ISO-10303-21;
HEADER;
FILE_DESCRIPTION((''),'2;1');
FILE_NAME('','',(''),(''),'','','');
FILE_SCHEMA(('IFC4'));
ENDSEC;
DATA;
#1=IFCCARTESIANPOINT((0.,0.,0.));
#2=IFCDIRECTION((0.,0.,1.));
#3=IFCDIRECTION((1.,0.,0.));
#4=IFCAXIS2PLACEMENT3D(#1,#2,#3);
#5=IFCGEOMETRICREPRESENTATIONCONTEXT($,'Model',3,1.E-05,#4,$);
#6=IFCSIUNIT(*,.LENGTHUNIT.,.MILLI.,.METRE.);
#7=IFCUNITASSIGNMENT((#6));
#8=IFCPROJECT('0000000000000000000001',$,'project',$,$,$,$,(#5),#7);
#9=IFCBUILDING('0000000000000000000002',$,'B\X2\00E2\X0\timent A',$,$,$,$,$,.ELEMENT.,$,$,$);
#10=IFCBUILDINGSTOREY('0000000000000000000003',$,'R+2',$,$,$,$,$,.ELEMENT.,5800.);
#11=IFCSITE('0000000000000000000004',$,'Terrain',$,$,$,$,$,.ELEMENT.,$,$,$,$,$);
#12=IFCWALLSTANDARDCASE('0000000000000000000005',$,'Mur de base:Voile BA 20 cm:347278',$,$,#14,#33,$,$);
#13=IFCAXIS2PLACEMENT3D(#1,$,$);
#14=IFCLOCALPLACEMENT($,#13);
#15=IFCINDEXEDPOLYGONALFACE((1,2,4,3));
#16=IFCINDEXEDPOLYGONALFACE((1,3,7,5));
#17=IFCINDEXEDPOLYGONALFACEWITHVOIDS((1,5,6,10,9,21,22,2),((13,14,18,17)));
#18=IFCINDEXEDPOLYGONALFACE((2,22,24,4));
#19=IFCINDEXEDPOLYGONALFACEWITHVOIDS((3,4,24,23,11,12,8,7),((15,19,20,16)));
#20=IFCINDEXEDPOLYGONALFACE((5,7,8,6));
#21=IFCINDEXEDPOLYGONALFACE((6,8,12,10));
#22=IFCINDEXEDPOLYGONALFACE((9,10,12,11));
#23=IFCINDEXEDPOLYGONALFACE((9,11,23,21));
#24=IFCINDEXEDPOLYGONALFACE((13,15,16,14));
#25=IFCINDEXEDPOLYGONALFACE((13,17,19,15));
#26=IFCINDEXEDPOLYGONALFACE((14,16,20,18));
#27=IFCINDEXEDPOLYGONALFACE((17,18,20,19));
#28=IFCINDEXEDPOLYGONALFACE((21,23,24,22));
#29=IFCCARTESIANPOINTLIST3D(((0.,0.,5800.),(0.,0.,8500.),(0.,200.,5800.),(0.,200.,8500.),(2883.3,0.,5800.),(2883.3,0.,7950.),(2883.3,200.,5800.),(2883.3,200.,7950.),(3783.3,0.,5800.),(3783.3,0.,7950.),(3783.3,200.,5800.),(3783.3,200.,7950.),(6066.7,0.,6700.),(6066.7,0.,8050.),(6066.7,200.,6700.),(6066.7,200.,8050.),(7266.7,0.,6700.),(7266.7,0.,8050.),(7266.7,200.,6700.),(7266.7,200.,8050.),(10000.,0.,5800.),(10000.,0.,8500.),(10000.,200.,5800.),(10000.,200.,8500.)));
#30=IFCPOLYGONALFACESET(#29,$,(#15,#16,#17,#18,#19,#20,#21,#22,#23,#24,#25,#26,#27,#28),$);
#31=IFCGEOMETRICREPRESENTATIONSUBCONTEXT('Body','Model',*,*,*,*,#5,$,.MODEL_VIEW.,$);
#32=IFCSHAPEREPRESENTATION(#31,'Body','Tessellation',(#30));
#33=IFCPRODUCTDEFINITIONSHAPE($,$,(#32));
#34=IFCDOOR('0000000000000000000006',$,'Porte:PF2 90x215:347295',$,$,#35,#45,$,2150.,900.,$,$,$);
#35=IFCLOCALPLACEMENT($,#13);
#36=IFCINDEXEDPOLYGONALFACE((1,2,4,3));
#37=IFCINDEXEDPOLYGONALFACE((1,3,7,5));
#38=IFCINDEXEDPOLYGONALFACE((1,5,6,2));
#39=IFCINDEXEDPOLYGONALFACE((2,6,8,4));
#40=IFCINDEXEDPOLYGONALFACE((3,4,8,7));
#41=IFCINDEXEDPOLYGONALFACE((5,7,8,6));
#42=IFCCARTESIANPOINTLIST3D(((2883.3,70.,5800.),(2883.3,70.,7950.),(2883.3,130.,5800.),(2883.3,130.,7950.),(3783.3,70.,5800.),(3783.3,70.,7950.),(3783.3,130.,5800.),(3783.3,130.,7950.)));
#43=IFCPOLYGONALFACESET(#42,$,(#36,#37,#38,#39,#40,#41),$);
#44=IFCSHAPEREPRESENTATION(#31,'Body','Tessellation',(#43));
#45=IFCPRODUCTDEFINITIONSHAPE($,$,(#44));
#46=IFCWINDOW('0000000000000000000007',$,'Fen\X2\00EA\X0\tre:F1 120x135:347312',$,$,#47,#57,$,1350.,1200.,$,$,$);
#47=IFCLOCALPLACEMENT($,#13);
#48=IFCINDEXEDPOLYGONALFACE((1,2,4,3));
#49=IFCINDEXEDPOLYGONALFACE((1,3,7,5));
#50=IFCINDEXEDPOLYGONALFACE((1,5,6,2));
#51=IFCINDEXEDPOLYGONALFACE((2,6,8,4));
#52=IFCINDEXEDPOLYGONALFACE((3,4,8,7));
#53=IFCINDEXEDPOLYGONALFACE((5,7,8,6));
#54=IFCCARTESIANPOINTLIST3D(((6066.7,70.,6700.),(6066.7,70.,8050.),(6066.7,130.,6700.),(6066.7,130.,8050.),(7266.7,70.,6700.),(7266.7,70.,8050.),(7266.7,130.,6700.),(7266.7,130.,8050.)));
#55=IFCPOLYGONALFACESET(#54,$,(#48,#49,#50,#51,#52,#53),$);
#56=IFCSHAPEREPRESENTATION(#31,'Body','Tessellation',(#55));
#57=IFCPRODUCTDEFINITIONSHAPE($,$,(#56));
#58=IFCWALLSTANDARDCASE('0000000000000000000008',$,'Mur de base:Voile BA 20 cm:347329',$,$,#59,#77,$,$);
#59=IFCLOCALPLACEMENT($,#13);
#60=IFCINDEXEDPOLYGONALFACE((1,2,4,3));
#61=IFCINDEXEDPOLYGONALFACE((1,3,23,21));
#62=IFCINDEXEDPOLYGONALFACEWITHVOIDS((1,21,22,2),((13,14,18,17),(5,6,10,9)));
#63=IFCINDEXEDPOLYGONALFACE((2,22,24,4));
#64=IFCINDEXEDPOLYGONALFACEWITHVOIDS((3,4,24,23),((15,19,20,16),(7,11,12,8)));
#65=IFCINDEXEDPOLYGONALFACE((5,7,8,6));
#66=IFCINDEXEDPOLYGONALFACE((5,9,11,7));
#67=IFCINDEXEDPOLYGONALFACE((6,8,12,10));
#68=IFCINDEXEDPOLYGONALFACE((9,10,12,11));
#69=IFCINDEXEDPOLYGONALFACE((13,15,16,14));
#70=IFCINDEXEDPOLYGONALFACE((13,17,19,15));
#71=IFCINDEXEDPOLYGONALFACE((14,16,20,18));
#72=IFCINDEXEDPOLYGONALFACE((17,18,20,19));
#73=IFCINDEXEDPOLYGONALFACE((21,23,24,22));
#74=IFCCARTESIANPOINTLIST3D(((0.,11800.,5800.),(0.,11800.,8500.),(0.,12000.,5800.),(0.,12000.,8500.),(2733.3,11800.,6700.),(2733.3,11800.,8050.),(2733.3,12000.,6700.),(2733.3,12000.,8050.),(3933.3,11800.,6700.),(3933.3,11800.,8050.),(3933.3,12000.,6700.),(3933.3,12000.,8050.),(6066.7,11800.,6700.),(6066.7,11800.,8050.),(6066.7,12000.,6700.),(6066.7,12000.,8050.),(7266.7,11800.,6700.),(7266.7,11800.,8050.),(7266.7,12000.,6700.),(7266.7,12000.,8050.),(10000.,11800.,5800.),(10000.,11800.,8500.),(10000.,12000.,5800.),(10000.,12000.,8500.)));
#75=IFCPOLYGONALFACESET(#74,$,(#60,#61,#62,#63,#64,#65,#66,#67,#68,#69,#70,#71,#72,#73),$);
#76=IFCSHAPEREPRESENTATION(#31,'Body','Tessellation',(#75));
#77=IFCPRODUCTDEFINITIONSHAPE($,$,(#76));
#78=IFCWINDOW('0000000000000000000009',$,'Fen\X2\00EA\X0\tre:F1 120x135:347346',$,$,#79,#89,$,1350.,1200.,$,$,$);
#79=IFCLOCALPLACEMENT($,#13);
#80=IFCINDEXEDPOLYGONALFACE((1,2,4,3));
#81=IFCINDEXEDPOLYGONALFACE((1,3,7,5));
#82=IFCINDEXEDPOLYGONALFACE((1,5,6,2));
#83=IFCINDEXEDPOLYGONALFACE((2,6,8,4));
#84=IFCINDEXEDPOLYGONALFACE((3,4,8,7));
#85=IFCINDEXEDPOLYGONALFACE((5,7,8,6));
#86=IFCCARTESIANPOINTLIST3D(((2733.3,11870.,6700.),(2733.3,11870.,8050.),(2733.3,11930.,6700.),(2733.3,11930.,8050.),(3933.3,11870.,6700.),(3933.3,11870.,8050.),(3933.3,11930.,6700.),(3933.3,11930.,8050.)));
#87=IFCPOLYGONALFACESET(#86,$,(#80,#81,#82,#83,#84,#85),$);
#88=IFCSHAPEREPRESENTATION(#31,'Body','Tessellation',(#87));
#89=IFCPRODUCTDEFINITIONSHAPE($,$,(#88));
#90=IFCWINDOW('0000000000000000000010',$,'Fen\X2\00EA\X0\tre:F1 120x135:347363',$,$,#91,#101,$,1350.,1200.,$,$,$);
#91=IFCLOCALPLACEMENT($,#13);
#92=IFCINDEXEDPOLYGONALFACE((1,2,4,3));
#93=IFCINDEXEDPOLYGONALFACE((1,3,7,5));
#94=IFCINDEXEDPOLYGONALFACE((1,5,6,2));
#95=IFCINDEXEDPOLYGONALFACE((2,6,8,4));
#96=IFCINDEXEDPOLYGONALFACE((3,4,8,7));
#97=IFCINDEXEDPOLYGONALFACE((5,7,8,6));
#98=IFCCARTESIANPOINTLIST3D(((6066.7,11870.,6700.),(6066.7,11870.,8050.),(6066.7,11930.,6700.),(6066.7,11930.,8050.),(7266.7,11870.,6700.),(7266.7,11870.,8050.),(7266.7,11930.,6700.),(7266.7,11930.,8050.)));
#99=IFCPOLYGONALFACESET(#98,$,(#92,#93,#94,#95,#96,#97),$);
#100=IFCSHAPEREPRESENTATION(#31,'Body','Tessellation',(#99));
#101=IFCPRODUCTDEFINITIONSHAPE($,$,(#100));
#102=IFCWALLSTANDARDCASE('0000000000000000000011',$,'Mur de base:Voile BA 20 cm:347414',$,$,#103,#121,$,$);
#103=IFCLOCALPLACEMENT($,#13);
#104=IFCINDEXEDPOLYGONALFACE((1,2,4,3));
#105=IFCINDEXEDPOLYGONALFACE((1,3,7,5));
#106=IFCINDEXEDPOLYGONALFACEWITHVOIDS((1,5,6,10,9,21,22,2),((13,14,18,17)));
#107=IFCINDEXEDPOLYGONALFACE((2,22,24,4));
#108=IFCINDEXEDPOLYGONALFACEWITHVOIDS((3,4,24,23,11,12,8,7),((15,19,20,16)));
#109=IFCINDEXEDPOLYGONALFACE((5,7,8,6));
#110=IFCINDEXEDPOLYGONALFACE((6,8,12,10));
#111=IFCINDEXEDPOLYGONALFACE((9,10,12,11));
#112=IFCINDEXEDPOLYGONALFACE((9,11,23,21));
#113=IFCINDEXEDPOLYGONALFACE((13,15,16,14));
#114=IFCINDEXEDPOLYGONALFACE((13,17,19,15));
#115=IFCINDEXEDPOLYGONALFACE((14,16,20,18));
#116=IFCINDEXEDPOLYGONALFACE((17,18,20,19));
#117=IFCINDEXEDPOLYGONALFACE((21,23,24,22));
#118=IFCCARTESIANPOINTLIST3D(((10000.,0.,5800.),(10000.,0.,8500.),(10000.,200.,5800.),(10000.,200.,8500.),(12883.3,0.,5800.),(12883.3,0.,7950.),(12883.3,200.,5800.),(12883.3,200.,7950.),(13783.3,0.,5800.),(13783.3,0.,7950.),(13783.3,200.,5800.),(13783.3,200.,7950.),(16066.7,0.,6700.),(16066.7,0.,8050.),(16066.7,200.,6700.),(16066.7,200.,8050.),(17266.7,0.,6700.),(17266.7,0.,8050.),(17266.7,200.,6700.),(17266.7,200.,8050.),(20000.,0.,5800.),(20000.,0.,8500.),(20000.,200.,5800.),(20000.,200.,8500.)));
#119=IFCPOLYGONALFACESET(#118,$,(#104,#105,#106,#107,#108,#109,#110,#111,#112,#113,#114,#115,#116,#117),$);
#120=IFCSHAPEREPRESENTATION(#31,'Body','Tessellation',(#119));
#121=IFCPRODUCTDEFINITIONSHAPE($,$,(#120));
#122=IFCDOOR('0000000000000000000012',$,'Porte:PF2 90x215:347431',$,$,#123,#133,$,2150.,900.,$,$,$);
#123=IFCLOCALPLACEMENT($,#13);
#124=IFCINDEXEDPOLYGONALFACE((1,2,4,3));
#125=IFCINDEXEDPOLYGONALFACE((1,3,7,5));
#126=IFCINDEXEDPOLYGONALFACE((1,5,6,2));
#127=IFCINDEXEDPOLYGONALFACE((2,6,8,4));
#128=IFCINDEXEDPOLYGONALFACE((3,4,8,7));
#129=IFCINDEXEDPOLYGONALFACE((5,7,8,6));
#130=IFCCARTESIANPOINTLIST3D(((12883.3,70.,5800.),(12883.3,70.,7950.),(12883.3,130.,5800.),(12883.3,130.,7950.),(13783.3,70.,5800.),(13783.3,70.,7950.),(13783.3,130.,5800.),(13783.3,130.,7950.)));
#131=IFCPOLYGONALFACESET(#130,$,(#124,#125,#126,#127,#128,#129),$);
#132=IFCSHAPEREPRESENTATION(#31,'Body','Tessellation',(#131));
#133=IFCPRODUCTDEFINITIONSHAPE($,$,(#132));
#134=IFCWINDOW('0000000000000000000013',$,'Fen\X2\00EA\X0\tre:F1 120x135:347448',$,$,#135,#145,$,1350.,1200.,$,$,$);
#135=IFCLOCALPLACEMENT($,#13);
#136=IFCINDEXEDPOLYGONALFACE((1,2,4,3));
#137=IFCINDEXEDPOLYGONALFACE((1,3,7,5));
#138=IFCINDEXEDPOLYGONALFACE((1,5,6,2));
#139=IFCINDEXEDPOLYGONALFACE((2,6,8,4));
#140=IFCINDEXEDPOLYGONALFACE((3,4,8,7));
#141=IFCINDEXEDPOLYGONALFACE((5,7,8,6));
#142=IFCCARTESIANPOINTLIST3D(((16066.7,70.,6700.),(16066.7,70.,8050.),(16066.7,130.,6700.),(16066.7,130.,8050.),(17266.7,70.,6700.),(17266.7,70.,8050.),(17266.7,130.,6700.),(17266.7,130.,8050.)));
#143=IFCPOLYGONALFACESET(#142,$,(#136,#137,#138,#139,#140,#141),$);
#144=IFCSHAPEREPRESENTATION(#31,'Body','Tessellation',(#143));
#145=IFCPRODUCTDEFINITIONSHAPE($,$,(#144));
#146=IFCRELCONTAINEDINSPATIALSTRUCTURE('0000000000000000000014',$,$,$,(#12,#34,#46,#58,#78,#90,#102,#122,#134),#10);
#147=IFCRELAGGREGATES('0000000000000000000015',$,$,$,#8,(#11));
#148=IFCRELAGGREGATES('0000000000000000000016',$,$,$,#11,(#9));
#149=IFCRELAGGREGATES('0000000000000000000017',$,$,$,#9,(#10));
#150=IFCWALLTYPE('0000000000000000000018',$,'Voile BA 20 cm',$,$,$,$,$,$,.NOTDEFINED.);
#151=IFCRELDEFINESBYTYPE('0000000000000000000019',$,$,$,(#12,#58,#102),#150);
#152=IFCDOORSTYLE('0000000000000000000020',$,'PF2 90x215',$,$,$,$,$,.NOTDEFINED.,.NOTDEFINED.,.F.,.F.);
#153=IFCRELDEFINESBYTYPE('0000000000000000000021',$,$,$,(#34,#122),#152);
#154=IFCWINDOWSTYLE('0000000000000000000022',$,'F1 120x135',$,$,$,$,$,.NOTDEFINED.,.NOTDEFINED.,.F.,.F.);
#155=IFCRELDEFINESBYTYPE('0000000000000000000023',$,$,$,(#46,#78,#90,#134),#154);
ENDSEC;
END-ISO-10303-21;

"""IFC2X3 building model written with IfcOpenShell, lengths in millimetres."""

from ifc_helpers import new_model, si_unit, frame, frame_2d, origin_with_axes, place, context, subcontext, project, spatial, rectangle, extrude, type_object, element, fill, save


model = new_model("IFC2X3")

# Units and contexts
model_context = context("Model", 3, precision=1e-05, world=origin_with_axes())
body_context = subcontext(model_context, "Body", "Model", "MODEL_VIEW")
ifc_project = project(units=[si_unit("LENGTHUNIT", "METRE", prefix="MILLI")], contexts=[model_context])

# Site, building, storey
site = spatial("IfcSite", under=ifc_project, Name="Terrain", CompositionType="ELEMENT")
building = spatial("IfcBuilding", under=site, Name="Bâtiment A", CompositionType="ELEMENT")
storey = spatial("IfcBuildingStorey", under=building, Name="R+2", CompositionType="ELEMENT", Elevation=5800.0)

# Wall, openings, door, window
wall_type_1 = type_object("IfcWallType", Name="Voile BA 20 cm", PredefinedType="NOTDEFINED")
wall_1_placement = place(None, origin_with_axes())
wall_1 = element("IfcWallStandardCase", 1, at=wall_1_placement, inside=storey, type_object=wall_type_1, Name="Mur de base:Voile BA 20 cm:347278", context=body_context, shape_type="SweptSolid", body=[
    extrude(rectangle(XDim=10000.0, YDim=200.0, at=frame_2d((5000.0, 100.0))), frame((0.0, 0.0, 5800.0), z_axis=(0.0, 0.0, 1.0), x_axis=(1.0, 0.0, 0.0)), (0.0, 0.0, 1.0), 2700.0),
])
opening_1_placement = place(None, origin_with_axes())
opening_1 = element("IfcOpeningElement", 2, at=opening_1_placement, cuts=wall_1, context=body_context, shape_type="SweptSolid", body=[
    extrude(rectangle(XDim=900.0, YDim=320.0, at=frame_2d((3333.3, 100.0))), frame((0.0, 0.0, 5800.0), z_axis=(0.0, 0.0, 1.0), x_axis=(1.0, 0.0, 0.0)), (0.0, 0.0, 1.0), 2150.0),
])
opening_2_placement = place(None, origin_with_axes())
opening_2 = element("IfcOpeningElement", 3, at=opening_2_placement, cuts=wall_1, context=body_context, shape_type="SweptSolid", body=[
    extrude(rectangle(XDim=1200.0, YDim=320.0, at=frame_2d((6666.7, 100.0))), frame((0.0, 0.0, 6700.0), z_axis=(0.0, 0.0, 1.0), x_axis=(1.0, 0.0, 0.0)), (0.0, 0.0, 1.0), 1350.0),
])
door_style = type_object("IfcDoorStyle", Name="PF2 90x215", ConstructionType="NOTDEFINED", OperationType="NOTDEFINED", ParameterTakesPrecedence=False, Sizeable=False)
door_1_placement = place(None, origin_with_axes())
door_1 = element("IfcDoor", 4, at=door_1_placement, inside=storey, type_object=door_style, Name="Porte:PF2 90x215:347295", OverallHeight=2150.0, OverallWidth=900.0, context=body_context, shape_type="SweptSolid", body=[
    extrude(rectangle(XDim=900.0, YDim=60.0, at=frame_2d((3333.3, 100.0))), frame((0.0, 0.0, 5800.0), z_axis=(0.0, 0.0, 1.0), x_axis=(1.0, 0.0, 0.0)), (0.0, 0.0, 1.0), 2150.0),
])
fill(opening_1, door_1)
window_style = type_object("IfcWindowStyle", Name="F1 120x135", ConstructionType="NOTDEFINED", OperationType="NOTDEFINED", ParameterTakesPrecedence=False, Sizeable=False)
window_1_placement = place(None, origin_with_axes())
window_1 = element("IfcWindow", 5, at=window_1_placement, inside=storey, type_object=window_style, Name="Fenêtre:F1 120x135:347312", OverallHeight=1350.0, OverallWidth=1200.0, context=body_context, shape_type="SweptSolid", body=[
    extrude(rectangle(XDim=1200.0, YDim=60.0, at=frame_2d((6666.7, 100.0))), frame((0.0, 0.0, 6700.0), z_axis=(0.0, 0.0, 1.0), x_axis=(1.0, 0.0, 0.0)), (0.0, 0.0, 1.0), 1350.0),
])
fill(opening_2, window_1)

# Wall, openings, windows
wall_2_placement = place(None, origin_with_axes())
wall_2 = element("IfcWallStandardCase", 6, at=wall_2_placement, inside=storey, type_object=wall_type_1, Name="Mur de base:Voile BA 20 cm:347329", context=body_context, shape_type="SweptSolid", body=[
    extrude(rectangle(XDim=10000.0, YDim=200.0, at=frame_2d((5000.0, 11900.0))), frame((0.0, 0.0, 5800.0), z_axis=(0.0, 0.0, 1.0), x_axis=(1.0, 0.0, 0.0)), (0.0, 0.0, 1.0), 2700.0),
])
opening_3_placement = place(None, origin_with_axes())
opening_3 = element("IfcOpeningElement", 7, at=opening_3_placement, cuts=wall_2, context=body_context, shape_type="SweptSolid", body=[
    extrude(rectangle(XDim=1200.0, YDim=320.0, at=frame_2d((3333.3, 11900.0))), frame((0.0, 0.0, 6700.0), z_axis=(0.0, 0.0, 1.0), x_axis=(1.0, 0.0, 0.0)), (0.0, 0.0, 1.0), 1350.0),
])
opening_4_placement = place(None, origin_with_axes())
opening_4 = element("IfcOpeningElement", 8, at=opening_4_placement, cuts=wall_2, context=body_context, shape_type="SweptSolid", body=[
    extrude(rectangle(XDim=1200.0, YDim=320.0, at=frame_2d((6666.7, 11900.0))), frame((0.0, 0.0, 6700.0), z_axis=(0.0, 0.0, 1.0), x_axis=(1.0, 0.0, 0.0)), (0.0, 0.0, 1.0), 1350.0),
])
window_2_placement = place(None, origin_with_axes())
window_2 = element("IfcWindow", 9, at=window_2_placement, inside=storey, type_object=window_style, Name="Fenêtre:F1 120x135:347346", OverallHeight=1350.0, OverallWidth=1200.0, context=body_context, shape_type="SweptSolid", body=[
    extrude(rectangle(XDim=1200.0, YDim=60.0, at=frame_2d((3333.3, 11900.0))), frame((0.0, 0.0, 6700.0), z_axis=(0.0, 0.0, 1.0), x_axis=(1.0, 0.0, 0.0)), (0.0, 0.0, 1.0), 1350.0),
])
fill(opening_3, window_2)
window_3_placement = place(None, origin_with_axes())
window_3 = element("IfcWindow", 10, at=window_3_placement, inside=storey, type_object=window_style, Name="Fenêtre:F1 120x135:347363", OverallHeight=1350.0, OverallWidth=1200.0, context=body_context, shape_type="SweptSolid", body=[
    extrude(rectangle(XDim=1200.0, YDim=60.0, at=frame_2d((6666.7, 11900.0))), frame((0.0, 0.0, 6700.0), z_axis=(0.0, 0.0, 1.0), x_axis=(1.0, 0.0, 0.0)), (0.0, 0.0, 1.0), 1350.0),
])
fill(opening_4, window_3)

# Wall, openings, door, window
wall_3_placement = place(None, origin_with_axes())
wall_3 = element("IfcWallStandardCase", 11, at=wall_3_placement, inside=storey, type_object=wall_type_1, Name="Mur de base:Voile BA 20 cm:347414", context=body_context, shape_type="SweptSolid", body=[
    extrude(rectangle(XDim=10000.0, YDim=200.0, at=frame_2d((15000.0, 100.0))), frame((0.0, 0.0, 5800.0), z_axis=(0.0, 0.0, 1.0), x_axis=(1.0, 0.0, 0.0)), (0.0, 0.0, 1.0), 2700.0),
])
opening_5_placement = place(None, origin_with_axes())
opening_5 = element("IfcOpeningElement", 12, at=opening_5_placement, cuts=wall_3, context=body_context, shape_type="SweptSolid", body=[
    extrude(rectangle(XDim=900.0, YDim=320.0, at=frame_2d((13333.3, 100.0))), frame((0.0, 0.0, 5800.0), z_axis=(0.0, 0.0, 1.0), x_axis=(1.0, 0.0, 0.0)), (0.0, 0.0, 1.0), 2150.0),
])
opening_6_placement = place(None, origin_with_axes())
opening_6 = element("IfcOpeningElement", 13, at=opening_6_placement, cuts=wall_3, context=body_context, shape_type="SweptSolid", body=[
    extrude(rectangle(XDim=1200.0, YDim=320.0, at=frame_2d((16666.7, 100.0))), frame((0.0, 0.0, 6700.0), z_axis=(0.0, 0.0, 1.0), x_axis=(1.0, 0.0, 0.0)), (0.0, 0.0, 1.0), 1350.0),
])
door_2_placement = place(None, origin_with_axes())
door_2 = element("IfcDoor", 14, at=door_2_placement, inside=storey, type_object=door_style, Name="Porte:PF2 90x215:347431", OverallHeight=2150.0, OverallWidth=900.0, context=body_context, shape_type="SweptSolid", body=[
    extrude(rectangle(XDim=900.0, YDim=60.0, at=frame_2d((13333.3, 100.0))), frame((0.0, 0.0, 5800.0), z_axis=(0.0, 0.0, 1.0), x_axis=(1.0, 0.0, 0.0)), (0.0, 0.0, 1.0), 2150.0),
])
fill(opening_5, door_2)
window_4_placement = place(None, origin_with_axes())
window_4 = element("IfcWindow", 15, at=window_4_placement, inside=storey, type_object=window_style, Name="Fenêtre:F1 120x135:347448", OverallHeight=1350.0, OverallWidth=1200.0, context=body_context, shape_type="SweptSolid", body=[
    extrude(rectangle(XDim=1200.0, YDim=60.0, at=frame_2d((16666.7, 100.0))), frame((0.0, 0.0, 6700.0), z_axis=(0.0, 0.0, 1.0), x_axis=(1.0, 0.0, 0.0)), (0.0, 0.0, 1.0), 1350.0),
])
fill(opening_6, window_4)

save(model, "model.ifc")
